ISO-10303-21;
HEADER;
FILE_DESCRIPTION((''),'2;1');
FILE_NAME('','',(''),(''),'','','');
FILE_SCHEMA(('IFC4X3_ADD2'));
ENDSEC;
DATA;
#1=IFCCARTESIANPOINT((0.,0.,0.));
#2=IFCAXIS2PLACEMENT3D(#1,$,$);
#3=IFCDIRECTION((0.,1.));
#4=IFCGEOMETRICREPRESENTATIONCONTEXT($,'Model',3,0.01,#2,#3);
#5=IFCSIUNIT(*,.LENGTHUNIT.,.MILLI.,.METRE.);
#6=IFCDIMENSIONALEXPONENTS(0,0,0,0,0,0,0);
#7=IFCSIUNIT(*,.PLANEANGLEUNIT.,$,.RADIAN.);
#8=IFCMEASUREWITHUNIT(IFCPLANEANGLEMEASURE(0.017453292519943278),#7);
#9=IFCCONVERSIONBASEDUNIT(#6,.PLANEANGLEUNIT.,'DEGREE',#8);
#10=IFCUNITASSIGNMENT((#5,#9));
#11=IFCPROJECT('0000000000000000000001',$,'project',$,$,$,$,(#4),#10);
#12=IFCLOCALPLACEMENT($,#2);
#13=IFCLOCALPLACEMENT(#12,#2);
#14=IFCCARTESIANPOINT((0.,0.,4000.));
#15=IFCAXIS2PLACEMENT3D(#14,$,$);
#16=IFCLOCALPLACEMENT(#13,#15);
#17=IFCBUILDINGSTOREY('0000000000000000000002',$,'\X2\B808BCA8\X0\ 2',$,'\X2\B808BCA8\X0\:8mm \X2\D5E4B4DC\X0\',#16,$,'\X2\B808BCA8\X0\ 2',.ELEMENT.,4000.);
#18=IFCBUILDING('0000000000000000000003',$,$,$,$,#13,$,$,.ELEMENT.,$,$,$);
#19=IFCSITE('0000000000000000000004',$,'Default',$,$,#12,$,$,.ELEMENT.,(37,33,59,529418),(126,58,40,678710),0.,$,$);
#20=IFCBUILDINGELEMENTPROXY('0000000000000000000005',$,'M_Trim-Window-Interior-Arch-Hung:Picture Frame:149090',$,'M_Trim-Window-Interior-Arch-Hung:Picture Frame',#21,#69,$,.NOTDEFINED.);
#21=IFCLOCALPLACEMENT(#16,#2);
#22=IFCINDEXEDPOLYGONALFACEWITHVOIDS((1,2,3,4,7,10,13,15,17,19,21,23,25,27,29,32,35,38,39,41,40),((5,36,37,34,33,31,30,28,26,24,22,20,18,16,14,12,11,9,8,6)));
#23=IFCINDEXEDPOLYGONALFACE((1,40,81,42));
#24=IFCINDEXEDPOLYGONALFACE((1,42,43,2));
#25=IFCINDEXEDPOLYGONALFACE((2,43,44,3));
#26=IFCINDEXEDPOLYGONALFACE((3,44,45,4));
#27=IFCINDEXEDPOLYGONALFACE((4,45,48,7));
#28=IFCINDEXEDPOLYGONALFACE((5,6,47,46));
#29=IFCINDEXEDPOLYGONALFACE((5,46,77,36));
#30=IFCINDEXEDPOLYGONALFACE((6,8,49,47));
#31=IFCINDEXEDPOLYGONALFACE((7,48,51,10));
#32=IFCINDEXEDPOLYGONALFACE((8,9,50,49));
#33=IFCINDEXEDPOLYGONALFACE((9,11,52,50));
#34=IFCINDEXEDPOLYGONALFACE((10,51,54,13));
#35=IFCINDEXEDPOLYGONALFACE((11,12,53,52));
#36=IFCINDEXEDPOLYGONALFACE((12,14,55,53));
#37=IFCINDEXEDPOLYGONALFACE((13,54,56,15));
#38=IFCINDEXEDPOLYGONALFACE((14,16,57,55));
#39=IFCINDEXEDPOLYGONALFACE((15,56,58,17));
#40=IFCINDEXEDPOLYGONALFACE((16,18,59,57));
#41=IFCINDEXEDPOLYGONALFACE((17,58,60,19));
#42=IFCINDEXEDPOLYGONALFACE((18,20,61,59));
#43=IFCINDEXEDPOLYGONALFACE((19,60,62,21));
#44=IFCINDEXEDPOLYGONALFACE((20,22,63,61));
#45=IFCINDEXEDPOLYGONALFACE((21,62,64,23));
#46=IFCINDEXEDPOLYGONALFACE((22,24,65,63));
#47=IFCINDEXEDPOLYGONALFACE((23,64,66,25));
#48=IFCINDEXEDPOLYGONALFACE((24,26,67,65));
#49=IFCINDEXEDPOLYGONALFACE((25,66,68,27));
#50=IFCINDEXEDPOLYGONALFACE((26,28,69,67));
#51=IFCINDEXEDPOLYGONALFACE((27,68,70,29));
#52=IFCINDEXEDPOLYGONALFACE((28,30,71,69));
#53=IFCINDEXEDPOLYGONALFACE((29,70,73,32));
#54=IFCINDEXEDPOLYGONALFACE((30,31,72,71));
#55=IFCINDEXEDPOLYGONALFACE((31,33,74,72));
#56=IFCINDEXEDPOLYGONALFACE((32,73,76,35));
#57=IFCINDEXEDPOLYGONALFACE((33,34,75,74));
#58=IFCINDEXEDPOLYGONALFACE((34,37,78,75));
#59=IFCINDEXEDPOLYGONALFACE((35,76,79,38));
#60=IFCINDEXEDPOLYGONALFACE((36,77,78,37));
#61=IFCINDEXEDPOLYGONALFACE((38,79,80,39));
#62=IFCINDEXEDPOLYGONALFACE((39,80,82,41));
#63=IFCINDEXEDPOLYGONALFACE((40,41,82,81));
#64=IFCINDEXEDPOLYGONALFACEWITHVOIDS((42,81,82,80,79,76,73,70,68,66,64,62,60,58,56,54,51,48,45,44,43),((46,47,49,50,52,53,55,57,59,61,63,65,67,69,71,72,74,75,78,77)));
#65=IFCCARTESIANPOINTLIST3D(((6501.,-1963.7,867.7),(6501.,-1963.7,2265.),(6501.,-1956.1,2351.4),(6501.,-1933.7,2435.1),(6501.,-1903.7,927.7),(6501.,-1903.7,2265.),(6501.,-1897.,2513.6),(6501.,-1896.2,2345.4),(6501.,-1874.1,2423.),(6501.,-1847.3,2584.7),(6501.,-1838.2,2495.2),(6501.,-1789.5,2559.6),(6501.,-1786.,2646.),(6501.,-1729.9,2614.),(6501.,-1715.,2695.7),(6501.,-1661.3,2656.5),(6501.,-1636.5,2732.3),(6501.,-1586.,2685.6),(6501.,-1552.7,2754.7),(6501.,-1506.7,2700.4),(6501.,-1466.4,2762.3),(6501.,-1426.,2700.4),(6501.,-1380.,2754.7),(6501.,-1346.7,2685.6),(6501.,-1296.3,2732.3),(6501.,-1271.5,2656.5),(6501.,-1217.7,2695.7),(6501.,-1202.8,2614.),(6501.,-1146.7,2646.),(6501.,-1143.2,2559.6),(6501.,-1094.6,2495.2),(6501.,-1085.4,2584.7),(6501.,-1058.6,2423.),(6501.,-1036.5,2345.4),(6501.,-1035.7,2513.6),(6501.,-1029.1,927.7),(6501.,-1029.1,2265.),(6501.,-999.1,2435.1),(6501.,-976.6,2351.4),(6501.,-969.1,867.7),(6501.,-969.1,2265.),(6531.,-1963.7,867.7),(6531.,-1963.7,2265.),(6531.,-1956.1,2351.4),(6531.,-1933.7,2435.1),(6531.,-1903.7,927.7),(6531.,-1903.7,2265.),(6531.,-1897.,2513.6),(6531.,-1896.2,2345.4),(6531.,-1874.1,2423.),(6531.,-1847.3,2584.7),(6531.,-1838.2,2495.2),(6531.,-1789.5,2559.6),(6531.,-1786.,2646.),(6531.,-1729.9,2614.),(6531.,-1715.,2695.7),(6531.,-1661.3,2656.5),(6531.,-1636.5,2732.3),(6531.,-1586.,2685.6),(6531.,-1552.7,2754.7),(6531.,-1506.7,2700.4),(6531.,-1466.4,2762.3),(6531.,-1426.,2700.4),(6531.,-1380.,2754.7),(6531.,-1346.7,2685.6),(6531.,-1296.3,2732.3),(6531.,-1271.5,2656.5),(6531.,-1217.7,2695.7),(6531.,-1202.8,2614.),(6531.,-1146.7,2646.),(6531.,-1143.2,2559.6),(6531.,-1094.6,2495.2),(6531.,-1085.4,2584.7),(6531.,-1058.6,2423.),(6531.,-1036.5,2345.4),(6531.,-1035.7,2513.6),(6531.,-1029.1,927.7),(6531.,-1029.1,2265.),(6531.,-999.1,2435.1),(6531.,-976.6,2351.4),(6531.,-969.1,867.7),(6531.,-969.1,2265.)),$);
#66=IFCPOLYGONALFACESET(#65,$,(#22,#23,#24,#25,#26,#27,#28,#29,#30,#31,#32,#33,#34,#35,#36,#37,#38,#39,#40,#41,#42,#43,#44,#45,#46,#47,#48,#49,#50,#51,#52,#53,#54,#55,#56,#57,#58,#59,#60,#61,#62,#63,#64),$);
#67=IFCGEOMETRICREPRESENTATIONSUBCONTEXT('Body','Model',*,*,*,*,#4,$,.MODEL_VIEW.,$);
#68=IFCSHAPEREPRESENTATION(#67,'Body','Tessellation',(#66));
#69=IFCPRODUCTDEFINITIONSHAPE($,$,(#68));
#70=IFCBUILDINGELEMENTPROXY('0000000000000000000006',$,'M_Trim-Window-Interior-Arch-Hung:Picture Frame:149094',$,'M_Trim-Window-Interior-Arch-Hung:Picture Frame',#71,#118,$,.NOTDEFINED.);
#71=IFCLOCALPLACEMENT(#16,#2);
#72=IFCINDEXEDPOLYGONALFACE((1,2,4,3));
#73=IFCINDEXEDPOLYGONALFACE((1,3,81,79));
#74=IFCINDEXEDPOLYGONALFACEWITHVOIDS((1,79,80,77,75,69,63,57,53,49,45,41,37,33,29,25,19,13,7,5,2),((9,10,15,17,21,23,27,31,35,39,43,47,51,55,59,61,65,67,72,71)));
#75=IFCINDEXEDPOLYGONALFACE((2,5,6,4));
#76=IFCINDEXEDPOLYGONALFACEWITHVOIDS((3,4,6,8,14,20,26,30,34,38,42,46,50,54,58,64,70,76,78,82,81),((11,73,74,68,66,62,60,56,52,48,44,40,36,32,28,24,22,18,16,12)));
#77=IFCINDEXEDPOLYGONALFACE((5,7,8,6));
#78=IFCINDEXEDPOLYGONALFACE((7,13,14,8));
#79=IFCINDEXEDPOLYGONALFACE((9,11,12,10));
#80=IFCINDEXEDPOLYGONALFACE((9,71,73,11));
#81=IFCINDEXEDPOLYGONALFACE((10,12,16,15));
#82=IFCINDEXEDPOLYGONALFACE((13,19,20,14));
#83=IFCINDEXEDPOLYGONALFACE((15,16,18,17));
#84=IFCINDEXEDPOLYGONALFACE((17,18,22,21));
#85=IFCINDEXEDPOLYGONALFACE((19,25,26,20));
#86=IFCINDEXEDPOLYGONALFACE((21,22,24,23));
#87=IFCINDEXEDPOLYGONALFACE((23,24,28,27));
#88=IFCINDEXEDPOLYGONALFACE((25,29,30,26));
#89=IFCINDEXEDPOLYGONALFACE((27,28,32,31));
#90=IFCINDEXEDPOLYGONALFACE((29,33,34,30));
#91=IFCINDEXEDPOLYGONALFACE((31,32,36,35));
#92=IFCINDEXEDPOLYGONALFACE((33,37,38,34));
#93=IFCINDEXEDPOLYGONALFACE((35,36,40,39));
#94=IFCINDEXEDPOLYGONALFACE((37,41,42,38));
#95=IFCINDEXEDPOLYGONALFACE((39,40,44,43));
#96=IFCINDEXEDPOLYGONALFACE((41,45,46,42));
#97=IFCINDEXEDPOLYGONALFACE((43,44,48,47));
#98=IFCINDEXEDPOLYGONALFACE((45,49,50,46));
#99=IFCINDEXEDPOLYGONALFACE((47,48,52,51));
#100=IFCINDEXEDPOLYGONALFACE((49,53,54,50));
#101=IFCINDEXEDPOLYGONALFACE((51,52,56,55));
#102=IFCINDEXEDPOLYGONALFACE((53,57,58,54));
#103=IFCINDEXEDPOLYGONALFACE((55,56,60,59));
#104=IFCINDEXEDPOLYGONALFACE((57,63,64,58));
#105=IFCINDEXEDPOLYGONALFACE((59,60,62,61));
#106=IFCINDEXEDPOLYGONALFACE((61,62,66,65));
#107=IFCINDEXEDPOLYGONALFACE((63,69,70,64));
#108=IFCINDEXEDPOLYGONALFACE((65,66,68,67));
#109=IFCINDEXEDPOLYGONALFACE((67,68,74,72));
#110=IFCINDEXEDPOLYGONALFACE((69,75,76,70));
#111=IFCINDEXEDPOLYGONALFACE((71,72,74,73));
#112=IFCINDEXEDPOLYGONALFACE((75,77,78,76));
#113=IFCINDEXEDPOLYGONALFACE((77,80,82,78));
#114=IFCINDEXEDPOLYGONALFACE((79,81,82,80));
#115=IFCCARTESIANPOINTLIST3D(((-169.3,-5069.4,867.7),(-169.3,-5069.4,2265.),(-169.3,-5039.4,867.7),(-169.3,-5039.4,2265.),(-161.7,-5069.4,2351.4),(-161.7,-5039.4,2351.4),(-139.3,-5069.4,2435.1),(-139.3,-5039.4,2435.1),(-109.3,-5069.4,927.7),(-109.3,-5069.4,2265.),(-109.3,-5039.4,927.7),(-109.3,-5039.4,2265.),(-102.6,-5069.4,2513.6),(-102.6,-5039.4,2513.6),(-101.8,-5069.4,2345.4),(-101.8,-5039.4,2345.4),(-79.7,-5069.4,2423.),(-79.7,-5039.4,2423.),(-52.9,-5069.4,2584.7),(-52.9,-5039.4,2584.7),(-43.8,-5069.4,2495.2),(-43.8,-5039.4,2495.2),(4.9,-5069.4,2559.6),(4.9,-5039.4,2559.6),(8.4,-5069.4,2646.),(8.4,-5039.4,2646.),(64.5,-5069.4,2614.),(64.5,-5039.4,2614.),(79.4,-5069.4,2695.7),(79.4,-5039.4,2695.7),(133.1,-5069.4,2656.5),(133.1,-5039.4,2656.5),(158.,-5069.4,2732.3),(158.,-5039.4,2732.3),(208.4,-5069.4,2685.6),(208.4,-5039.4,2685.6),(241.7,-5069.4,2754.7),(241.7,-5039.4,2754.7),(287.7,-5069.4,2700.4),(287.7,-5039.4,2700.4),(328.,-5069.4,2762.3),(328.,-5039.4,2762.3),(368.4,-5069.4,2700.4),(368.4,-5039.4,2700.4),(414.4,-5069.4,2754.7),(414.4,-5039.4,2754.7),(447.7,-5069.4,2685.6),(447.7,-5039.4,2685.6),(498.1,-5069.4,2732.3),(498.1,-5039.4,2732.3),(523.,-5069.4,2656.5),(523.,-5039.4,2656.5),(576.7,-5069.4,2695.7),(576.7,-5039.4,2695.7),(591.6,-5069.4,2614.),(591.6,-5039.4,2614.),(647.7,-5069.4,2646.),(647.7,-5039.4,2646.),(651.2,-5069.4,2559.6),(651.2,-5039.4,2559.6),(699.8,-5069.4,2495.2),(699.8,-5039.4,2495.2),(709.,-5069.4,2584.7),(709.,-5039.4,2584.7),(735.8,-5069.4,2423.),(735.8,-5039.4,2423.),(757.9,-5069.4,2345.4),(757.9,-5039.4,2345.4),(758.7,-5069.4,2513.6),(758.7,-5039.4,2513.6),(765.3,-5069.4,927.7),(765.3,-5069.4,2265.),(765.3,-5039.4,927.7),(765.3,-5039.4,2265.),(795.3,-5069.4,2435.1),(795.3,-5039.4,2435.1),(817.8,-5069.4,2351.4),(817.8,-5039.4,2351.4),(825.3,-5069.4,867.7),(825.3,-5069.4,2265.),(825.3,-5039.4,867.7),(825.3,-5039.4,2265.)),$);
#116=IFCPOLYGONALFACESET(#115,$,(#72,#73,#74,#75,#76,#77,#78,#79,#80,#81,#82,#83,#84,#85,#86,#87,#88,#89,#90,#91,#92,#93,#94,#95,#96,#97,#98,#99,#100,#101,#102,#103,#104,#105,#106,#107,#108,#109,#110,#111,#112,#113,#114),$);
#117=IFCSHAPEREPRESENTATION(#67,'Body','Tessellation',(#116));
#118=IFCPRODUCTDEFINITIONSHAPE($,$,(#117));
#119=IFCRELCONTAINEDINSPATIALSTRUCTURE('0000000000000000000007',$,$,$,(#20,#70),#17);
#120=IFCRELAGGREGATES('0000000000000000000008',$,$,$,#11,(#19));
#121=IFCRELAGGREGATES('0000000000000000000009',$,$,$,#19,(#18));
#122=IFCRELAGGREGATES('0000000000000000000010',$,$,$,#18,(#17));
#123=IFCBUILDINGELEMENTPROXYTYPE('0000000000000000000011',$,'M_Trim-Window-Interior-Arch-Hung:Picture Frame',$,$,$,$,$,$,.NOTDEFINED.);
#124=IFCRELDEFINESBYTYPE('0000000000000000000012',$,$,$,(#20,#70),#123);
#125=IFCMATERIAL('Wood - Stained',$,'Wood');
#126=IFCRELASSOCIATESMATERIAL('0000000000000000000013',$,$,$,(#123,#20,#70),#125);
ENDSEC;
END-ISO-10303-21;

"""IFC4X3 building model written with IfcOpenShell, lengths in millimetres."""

from ifc_helpers import new_model, entity, si_unit, converted_unit, direction, frame, frame_2d, origin, place, context, subcontext, project, spatial, polyline, circle_curve, parameter, trimmed, segment, composite_curve, outline, extrude, source, transform, mapped, material, type_object, type_shapes, element, save


model = new_model("IFC4X3")

# Units and contexts
model_context = context("Model", 3, precision=0.01, world=origin(), true_north=direction((0.0, 1.0)))
body_context = subcontext(model_context, "Body", "Model", "MODEL_VIEW")
ifc_project = project(units=[si_unit("LENGTHUNIT", "METRE", prefix="MILLI"), converted_unit("PLANEANGLEUNIT", "DEGREE", entity("IfcPlaneAngleMeasure", 0.017453292519943278), si_unit("PLANEANGLEUNIT", "RADIAN"), dimensions=[0, 0, 0, 0, 0, 0, 0])], contexts=[model_context])

# Site, building, storey
site_placement = place(None, origin())
site = spatial("IfcSite", under=ifc_project, at=site_placement, Name="Default", CompositionType="ELEMENT", RefLatitude=(37, 33, 59, 529418), RefLongitude=(126, 58, 40, 678710), RefElevation=0.0)
building_placement = place(site_placement, origin())
building = spatial("IfcBuilding", under=site, at=building_placement, CompositionType="ELEMENT")
storey_placement = place(building_placement, frame((0.0, 0.0, 4000.0)))
storey = spatial("IfcBuildingStorey", under=building, at=storey_placement, Name="레벨 2", ObjectType="레벨:8mm 헤드", LongName="레벨 2", CompositionType="ELEMENT", Elevation=4000.0)

# Building element proxies
ifc_material_1 = material(Name="Wood - Stained", Category="Wood")
building_element_proxy_type_1 = type_object("IfcBuildingElementProxyType", Name="M_Trim-Window-Interior-Arch-Hung:Picture Frame", PredefinedType="NOTDEFINED", material=ifc_material_1)
shared_shape_1 = source(origin(), body_context, "Body", "SweptSolid", [
    extrude(outline(composite_curve([segment(polyline([(-698.7, -497.3), (698.7, -497.3)]), True, "CONTINUOUS"), segment(polyline([(698.7, -497.3), (698.7, 497.3)]), True, "CONTINUOUS"), segment(polyline([(698.7, 497.3), (-698.7, 497.3)]), True, "CONTINUOUS"), segment(trimmed(circle_curve(frame_2d((-698.7, 0.0), x_axis=(0.0, 1.0)), 497.3), [parameter(0.0)], [parameter(180.0)], True, "PARAMETER"), True, "CONTINUOUS")], self_intersect=False), holes=[composite_curve([segment(trimmed(circle_curve(frame_2d((-698.7, 0.0), x_axis=(0.0, 1.0)), 437.3), [parameter(0.0)], [parameter(180.0)], True, "PARAMETER"), False, "CONTINUOUS"), segment(polyline([(-698.7, 437.3), (638.6, 437.3)]), True, "CONTINUOUS"), segment(polyline([(638.6, 437.3), (638.7, -437.3)]), True, "CONTINUOUS"), segment(polyline([(638.7, -437.3), (-698.7, -437.3)]), True, "CONTINUOUS")], self_intersect=False)]), frame((0.0, -1148.7, 0.0), z_axis=(0.0, 0.0, 1.0), x_axis=(0.0, -1.0, 0.0)), (0.0, 0.0, 1.0), 30.0),
])
type_shapes(building_element_proxy_type_1, [shared_shape_1])
for number, where, z_axis, x_axis, name in (
    (1, (6531.0, -1466.4, 2715.0), (-1.0, 0.0, 0.0), (0.0, -1.0, 0.0), "M_Trim-Window-Interior-Arch-Hung:Picture Frame:149090"),
    (2, (328.0, -5069.4, 2715.0), (0.0, 1.0, 0.0), (-1.0, 0.0, 0.0), "M_Trim-Window-Interior-Arch-Hung:Picture Frame:149094"),
):
    element("IfcBuildingElementProxy", number, at=place(storey_placement, frame(where, z_axis=z_axis, x_axis=x_axis)), inside=storey, type_object=building_element_proxy_type_1, material=ifc_material_1, Name=name, ObjectType="M_Trim-Window-Interior-Arch-Hung:Picture Frame", PredefinedType="NOTDEFINED", context=body_context, shape_type="MappedRepresentation", body=[
        mapped(shared_shape_1, transform((0.0, 0.0, 0.0), scale=1.0)),
    ])

save(model, "model.ifc")
